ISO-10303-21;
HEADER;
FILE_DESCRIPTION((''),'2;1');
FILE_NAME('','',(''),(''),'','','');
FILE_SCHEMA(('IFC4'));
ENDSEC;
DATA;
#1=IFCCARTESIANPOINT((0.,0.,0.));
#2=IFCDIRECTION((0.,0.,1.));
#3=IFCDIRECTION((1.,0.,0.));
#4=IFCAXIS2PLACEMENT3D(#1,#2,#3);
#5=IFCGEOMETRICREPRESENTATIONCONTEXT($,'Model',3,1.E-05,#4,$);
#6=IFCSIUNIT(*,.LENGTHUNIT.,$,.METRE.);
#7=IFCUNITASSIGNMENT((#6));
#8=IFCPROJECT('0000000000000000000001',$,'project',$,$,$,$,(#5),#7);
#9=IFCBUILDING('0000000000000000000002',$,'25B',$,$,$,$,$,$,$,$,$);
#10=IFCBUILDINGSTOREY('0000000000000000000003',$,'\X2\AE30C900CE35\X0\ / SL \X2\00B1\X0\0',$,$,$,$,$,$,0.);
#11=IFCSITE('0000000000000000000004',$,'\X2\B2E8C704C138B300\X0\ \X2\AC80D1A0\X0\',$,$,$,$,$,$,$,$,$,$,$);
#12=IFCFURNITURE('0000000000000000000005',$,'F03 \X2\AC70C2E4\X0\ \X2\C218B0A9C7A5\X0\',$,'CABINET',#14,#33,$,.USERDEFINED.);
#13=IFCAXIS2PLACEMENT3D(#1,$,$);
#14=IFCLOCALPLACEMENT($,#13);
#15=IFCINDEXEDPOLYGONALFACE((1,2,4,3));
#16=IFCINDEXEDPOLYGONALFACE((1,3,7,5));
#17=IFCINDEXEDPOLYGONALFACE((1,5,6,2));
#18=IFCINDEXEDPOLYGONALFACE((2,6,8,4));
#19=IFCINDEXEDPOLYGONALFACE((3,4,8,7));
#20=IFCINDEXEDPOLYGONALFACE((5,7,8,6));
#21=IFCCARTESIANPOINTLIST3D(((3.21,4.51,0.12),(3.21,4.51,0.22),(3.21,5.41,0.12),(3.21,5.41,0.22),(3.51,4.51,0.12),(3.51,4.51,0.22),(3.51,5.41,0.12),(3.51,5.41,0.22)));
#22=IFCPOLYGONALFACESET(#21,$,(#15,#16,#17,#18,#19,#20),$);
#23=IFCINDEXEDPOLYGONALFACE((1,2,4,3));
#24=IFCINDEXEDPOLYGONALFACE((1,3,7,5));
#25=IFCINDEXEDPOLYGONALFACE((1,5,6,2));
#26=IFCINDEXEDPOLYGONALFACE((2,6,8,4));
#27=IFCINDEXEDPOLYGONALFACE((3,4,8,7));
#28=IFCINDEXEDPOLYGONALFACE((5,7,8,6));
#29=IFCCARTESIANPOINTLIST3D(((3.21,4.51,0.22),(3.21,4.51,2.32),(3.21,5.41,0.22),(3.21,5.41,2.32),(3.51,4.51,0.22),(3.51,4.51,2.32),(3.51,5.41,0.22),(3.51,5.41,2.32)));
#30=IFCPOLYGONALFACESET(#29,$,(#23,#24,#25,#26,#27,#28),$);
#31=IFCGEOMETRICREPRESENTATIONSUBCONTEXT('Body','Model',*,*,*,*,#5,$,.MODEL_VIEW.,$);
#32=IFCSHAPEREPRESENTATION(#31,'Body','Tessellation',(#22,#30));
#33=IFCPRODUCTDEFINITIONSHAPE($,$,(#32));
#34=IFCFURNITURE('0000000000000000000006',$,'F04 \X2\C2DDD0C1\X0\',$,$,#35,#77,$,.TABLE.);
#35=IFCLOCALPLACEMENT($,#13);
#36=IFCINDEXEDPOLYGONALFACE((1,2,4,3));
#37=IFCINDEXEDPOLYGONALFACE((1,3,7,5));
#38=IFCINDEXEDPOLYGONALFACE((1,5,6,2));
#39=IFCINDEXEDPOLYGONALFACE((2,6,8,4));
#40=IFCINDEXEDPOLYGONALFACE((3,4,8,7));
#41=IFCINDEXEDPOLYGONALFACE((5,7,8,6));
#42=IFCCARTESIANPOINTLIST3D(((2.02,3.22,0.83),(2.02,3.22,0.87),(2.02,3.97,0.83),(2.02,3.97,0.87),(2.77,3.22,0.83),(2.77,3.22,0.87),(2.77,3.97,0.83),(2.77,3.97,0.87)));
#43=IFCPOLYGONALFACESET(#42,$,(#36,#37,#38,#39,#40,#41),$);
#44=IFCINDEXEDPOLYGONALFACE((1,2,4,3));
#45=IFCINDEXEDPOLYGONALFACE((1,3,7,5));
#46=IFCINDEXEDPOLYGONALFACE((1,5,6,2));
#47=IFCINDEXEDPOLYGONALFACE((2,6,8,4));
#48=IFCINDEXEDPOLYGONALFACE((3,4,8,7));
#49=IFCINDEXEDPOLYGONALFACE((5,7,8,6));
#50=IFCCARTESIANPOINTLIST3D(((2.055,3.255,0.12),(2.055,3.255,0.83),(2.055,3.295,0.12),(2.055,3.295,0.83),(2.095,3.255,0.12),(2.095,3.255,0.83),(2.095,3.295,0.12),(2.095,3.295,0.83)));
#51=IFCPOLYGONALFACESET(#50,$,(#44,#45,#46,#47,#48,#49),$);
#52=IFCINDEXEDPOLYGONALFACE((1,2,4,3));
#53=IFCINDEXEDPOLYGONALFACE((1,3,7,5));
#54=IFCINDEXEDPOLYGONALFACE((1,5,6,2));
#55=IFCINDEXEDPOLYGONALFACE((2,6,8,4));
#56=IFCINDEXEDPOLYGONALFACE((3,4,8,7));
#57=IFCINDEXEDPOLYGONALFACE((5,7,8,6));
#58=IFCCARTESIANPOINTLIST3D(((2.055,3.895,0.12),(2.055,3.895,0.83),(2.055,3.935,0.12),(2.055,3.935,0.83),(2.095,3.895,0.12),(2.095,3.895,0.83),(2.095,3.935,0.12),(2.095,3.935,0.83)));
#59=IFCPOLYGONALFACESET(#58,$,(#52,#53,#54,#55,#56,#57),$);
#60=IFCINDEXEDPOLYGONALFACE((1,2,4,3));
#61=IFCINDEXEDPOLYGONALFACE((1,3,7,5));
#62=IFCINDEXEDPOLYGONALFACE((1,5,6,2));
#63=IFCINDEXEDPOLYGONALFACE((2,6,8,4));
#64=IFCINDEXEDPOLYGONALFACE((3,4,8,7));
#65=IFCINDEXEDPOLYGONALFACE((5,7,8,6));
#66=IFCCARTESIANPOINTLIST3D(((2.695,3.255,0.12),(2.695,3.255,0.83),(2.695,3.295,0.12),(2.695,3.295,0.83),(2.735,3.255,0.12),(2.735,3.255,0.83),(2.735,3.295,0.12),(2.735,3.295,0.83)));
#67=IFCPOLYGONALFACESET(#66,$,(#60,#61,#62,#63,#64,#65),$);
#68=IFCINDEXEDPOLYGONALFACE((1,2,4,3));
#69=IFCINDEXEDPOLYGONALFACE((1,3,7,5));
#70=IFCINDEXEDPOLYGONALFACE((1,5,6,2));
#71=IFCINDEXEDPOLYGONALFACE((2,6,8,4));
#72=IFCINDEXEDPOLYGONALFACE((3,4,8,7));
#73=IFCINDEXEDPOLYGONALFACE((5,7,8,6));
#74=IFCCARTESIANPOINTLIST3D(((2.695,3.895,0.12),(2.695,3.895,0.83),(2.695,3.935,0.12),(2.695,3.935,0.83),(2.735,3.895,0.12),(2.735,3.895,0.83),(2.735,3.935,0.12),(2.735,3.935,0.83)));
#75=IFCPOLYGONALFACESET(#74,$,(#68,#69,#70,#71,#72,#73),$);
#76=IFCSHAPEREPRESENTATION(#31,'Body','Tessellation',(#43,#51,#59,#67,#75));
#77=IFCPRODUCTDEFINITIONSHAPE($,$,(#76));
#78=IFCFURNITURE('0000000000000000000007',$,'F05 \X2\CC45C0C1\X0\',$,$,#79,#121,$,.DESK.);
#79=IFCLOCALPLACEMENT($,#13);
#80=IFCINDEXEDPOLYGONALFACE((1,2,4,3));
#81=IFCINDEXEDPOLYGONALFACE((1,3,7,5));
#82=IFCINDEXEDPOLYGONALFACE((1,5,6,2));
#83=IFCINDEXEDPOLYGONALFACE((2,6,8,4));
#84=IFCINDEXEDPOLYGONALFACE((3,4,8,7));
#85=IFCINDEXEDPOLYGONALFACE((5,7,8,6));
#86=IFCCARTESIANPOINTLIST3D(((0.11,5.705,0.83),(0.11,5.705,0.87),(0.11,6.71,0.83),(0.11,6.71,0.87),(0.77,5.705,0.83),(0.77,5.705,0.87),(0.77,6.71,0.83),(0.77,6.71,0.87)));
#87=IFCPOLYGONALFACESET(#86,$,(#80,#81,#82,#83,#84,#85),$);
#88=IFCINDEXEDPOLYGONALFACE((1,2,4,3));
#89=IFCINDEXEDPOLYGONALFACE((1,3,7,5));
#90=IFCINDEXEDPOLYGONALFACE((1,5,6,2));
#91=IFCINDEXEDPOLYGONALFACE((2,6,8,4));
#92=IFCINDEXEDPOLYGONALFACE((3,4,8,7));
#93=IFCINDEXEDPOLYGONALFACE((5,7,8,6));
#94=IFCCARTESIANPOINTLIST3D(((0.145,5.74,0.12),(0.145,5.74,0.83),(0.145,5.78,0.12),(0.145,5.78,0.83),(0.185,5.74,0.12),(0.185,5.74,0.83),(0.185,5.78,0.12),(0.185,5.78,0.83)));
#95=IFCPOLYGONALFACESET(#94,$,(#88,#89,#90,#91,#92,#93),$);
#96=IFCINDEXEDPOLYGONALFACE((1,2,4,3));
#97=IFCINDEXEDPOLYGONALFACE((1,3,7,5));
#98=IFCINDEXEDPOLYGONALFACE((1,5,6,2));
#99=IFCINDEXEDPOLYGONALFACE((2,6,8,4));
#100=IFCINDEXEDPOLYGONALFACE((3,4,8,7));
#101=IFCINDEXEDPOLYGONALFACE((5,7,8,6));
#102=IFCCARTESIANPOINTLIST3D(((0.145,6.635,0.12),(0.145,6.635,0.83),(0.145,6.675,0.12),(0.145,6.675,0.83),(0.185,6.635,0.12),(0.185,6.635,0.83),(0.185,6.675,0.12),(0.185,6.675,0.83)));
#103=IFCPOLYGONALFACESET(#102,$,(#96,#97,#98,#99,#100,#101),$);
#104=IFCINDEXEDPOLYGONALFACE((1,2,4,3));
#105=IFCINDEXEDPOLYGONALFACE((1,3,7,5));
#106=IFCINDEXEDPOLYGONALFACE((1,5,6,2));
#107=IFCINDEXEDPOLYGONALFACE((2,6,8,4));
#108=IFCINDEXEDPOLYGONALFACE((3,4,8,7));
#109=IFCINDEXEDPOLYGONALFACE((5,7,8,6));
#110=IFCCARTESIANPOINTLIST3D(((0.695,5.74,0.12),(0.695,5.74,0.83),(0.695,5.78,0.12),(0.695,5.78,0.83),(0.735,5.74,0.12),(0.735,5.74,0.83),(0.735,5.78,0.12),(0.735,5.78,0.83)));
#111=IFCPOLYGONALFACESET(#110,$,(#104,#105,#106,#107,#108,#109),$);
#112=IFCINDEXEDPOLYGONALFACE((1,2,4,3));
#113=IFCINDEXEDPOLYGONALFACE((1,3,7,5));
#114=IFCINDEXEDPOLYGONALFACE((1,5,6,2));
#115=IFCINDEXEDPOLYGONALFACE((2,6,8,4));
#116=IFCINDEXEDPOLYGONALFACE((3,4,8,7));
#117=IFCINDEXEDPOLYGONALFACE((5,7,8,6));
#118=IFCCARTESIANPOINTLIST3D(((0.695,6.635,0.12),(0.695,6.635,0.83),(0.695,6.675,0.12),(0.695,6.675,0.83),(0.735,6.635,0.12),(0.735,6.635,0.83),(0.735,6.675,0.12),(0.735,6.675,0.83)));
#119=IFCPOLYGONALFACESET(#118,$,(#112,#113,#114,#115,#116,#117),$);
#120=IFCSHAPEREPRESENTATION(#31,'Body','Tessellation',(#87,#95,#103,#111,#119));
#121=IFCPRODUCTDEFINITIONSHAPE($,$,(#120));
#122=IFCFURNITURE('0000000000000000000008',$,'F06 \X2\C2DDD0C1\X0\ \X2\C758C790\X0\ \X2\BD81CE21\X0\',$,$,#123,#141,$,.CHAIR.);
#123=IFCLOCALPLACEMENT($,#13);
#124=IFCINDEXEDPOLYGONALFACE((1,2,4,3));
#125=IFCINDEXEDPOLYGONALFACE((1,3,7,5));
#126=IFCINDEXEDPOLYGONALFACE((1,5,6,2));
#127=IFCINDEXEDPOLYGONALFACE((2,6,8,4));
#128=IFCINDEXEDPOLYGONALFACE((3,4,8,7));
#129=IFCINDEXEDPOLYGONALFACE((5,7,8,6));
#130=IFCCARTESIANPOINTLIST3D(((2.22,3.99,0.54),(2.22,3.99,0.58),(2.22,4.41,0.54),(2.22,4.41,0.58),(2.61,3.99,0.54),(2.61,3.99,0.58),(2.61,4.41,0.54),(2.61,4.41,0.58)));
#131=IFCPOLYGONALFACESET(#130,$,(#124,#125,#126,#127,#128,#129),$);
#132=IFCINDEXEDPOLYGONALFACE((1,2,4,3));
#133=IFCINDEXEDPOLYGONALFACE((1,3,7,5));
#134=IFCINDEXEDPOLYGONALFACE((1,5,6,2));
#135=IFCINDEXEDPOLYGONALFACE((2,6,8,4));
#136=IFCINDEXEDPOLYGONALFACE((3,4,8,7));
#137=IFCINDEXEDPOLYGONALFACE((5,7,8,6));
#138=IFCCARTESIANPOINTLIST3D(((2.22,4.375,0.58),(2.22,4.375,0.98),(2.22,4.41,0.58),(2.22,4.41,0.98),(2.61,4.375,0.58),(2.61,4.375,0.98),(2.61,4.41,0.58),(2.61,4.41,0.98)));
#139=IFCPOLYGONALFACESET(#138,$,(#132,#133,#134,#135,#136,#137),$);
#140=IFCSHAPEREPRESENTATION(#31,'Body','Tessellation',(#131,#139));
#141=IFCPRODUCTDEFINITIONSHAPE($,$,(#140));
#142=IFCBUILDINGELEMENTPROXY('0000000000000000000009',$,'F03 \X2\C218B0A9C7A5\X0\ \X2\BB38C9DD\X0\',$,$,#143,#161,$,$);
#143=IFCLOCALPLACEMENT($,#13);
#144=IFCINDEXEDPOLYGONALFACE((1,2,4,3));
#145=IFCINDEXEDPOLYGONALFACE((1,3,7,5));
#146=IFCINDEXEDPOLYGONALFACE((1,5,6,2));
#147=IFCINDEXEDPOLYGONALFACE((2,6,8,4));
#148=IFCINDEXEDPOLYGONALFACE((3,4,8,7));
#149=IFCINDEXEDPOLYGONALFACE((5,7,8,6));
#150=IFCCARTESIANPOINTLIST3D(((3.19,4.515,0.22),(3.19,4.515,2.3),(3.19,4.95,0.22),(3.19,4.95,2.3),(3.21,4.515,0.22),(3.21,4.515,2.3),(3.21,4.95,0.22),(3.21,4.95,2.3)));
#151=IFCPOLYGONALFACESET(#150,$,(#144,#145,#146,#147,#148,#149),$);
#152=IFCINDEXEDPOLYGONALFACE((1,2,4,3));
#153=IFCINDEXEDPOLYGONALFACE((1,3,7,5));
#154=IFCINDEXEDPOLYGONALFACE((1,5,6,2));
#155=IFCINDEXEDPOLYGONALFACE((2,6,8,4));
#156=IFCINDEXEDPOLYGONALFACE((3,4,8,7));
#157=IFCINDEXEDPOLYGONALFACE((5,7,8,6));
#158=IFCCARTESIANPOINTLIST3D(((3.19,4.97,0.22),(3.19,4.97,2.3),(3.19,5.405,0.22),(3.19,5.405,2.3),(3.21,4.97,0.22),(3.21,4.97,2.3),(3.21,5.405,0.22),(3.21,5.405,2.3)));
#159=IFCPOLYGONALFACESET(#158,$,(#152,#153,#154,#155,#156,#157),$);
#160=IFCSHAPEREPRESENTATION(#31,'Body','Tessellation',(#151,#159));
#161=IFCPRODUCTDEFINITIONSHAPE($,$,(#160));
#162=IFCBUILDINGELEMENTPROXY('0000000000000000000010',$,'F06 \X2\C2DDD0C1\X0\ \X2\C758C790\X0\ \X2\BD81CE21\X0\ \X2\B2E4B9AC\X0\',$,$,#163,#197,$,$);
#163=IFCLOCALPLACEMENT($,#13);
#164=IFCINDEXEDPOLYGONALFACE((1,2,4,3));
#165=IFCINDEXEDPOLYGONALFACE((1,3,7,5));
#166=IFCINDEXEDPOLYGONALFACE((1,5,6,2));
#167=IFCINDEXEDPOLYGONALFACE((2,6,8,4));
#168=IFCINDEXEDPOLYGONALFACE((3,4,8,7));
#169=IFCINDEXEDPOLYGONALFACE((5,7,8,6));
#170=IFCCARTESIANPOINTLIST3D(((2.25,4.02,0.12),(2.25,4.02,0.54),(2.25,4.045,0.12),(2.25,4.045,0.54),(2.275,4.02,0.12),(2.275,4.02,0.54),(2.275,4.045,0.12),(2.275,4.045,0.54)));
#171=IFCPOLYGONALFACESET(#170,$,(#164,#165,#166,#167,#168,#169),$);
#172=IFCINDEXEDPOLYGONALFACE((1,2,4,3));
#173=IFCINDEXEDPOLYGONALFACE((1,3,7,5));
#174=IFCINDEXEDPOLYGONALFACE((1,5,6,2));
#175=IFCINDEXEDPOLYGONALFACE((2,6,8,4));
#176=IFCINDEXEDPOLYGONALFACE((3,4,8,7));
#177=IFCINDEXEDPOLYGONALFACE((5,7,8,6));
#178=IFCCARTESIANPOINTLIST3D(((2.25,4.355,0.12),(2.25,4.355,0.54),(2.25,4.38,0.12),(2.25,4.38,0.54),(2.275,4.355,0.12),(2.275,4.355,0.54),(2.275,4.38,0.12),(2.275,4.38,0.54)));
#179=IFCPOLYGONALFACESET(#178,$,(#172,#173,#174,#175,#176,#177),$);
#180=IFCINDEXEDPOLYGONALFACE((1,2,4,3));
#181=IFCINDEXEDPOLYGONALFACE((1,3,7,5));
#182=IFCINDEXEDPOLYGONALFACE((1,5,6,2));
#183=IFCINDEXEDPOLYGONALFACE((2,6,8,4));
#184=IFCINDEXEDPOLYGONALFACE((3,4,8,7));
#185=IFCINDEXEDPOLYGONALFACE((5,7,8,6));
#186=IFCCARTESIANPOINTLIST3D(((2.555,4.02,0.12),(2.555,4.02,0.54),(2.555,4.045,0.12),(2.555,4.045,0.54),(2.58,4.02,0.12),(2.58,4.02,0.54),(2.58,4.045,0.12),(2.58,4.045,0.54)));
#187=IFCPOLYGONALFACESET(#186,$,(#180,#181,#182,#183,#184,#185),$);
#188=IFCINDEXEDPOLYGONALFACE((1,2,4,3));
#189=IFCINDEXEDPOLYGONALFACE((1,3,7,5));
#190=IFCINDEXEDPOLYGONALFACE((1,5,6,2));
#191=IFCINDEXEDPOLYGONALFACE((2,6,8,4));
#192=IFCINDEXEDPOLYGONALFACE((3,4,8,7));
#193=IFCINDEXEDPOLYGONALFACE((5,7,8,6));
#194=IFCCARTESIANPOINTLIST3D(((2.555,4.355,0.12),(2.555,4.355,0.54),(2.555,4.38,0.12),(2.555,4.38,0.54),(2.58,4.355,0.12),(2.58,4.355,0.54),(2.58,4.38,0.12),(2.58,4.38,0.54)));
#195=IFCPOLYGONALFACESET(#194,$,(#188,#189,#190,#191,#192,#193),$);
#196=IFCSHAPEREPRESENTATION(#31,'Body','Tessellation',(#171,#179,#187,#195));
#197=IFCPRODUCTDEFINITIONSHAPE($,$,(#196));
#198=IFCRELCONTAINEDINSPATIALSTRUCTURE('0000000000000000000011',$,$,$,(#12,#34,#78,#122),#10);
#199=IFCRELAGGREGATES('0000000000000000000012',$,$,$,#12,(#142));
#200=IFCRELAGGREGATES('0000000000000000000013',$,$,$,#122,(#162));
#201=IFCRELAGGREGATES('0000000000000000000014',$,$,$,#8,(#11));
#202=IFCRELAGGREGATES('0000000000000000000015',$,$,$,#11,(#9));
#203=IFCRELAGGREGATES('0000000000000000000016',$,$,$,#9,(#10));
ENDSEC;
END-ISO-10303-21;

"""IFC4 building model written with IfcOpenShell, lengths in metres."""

from ifc_helpers import new_model, si_unit, frame, origin_with_axes, place, context, subcontext, project, spatial, polyline, outline, extrude, element, aggregate, save


model = new_model("IFC4")

# Units and contexts
model_context = context("Model", 3, precision=1e-05, world=origin_with_axes())
body_context = subcontext(model_context, "Body", "Model", "MODEL_VIEW")
ifc_project = project(units=[si_unit("LENGTHUNIT", "METRE")], contexts=[model_context])

# Site, building, storey
site = spatial("IfcSite", under=ifc_project, Name="단위세대 검토")
building = spatial("IfcBuilding", under=site, Name="25B")
storey = spatial("IfcBuildingStorey", under=building, Name="기준층 / SL ±0", Elevation=0.0)

# Furniture
furniture_1_placement = place(None, origin_with_axes())
furniture_1 = element("IfcFurniture", 1, at=furniture_1_placement, inside=storey, Name="F03 거실 수납장", ObjectType="CABINET", PredefinedType="USERDEFINED", context=body_context, shape_type="SweptSolid", body=[
    extrude(outline(polyline([(3.51, 4.51), (3.51, 5.41), (3.21, 5.41), (3.21, 4.51), (3.51, 4.51)])), frame((0.0, 0.0, 0.12)), (0.0, 0.0, 1.0), 0.1),
    extrude(outline(polyline([(3.51, 4.51), (3.51, 5.41), (3.21, 5.41), (3.21, 4.51), (3.51, 4.51)])), frame((0.0, 0.0, 0.22)), (0.0, 0.0, 1.0), 2.1),
])
furniture_2_placement = place(None, origin_with_axes())
element("IfcFurniture", 2, at=furniture_2_placement, inside=storey, Name="F04 식탁", PredefinedType="TABLE", context=body_context, shape_type="SweptSolid", body=[
    extrude(outline(polyline([(2.77, 3.97), (2.77, 3.22), (2.02, 3.22), (2.02, 3.97), (2.77, 3.97)])), frame((0.0, 0.0, 0.83)), (0.0, 0.0, 1.0), 0.04),
    extrude(outline(polyline([(2.095, 3.255), (2.095, 3.295), (2.055, 3.295), (2.055, 3.255), (2.095, 3.255)])), frame((0.0, 0.0, 0.12)), (0.0, 0.0, 1.0), 0.71),
    extrude(outline(polyline([(2.095, 3.895), (2.095, 3.935), (2.055, 3.935), (2.055, 3.895), (2.095, 3.895)])), frame((0.0, 0.0, 0.12)), (0.0, 0.0, 1.0), 0.71),
    extrude(outline(polyline([(2.735, 3.255), (2.735, 3.295), (2.695, 3.295), (2.695, 3.255), (2.735, 3.255)])), frame((0.0, 0.0, 0.12)), (0.0, 0.0, 1.0), 0.71),
    extrude(outline(polyline([(2.735, 3.895), (2.735, 3.935), (2.695, 3.935), (2.695, 3.895), (2.735, 3.895)])), frame((0.0, 0.0, 0.12)), (0.0, 0.0, 1.0), 0.71),
])
furniture_3_placement = place(None, origin_with_axes())
element("IfcFurniture", 3, at=furniture_3_placement, inside=storey, Name="F05 책상", PredefinedType="DESK", context=body_context, shape_type="SweptSolid", body=[
    extrude(outline(polyline([(0.77, 5.705), (0.77, 6.71), (0.11, 6.71), (0.11, 5.705), (0.77, 5.705)])), frame((0.0, 0.0, 0.83)), (0.0, 0.0, 1.0), 0.04),
    extrude(outline(polyline([(0.185, 5.74), (0.185, 5.78), (0.145, 5.78), (0.145, 5.74), (0.185, 5.74)])), frame((0.0, 0.0, 0.12)), (0.0, 0.0, 1.0), 0.71),
    extrude(outline(polyline([(0.185, 6.635), (0.185, 6.675), (0.145, 6.675), (0.145, 6.635), (0.185, 6.635)])), frame((0.0, 0.0, 0.12)), (0.0, 0.0, 1.0), 0.71),
    extrude(outline(polyline([(0.735, 5.74), (0.735, 5.78), (0.695, 5.78), (0.695, 5.74), (0.735, 5.74)])), frame((0.0, 0.0, 0.12)), (0.0, 0.0, 1.0), 0.71),
    extrude(outline(polyline([(0.735, 6.635), (0.735, 6.675), (0.695, 6.675), (0.695, 6.635), (0.735, 6.635)])), frame((0.0, 0.0, 0.12)), (0.0, 0.0, 1.0), 0.71),
])
furniture_4_placement = place(None, origin_with_axes())
furniture_4 = element("IfcFurniture", 4, at=furniture_4_placement, inside=storey, Name="F06 식탁 의자 북측", PredefinedType="CHAIR", context=body_context, shape_type="SweptSolid", body=[
    extrude(outline(polyline([(2.61, 3.99), (2.61, 4.41), (2.22, 4.41), (2.22, 3.99), (2.61, 3.99)])), frame((0.0, 0.0, 0.54)), (0.0, 0.0, 1.0), 0.04),
    extrude(outline(polyline([(2.61, 4.375), (2.61, 4.41), (2.22, 4.41), (2.22, 4.375), (2.61, 4.375)])), frame((0.0, 0.0, 0.58)), (0.0, 0.0, 1.0), 0.4),
])

# Building element proxies
proxy_1_placement = place(furniture_1_placement, origin_with_axes())
proxy_1 = element("IfcBuildingElementProxy", 5, at=proxy_1_placement, Name="F03 수납장 문짝", context=body_context, shape_type="SweptSolid", body=[
    extrude(outline(polyline([(3.21, 4.515), (3.21, 4.95), (3.19, 4.95), (3.19, 4.515), (3.21, 4.515)])), frame((0.0, 0.0, 0.22)), (0.0, 0.0, 1.0), 2.08),
    extrude(outline(polyline([(3.21, 4.97), (3.21, 5.405), (3.19, 5.405), (3.19, 4.97), (3.21, 4.97)])), frame((0.0, 0.0, 0.22)), (0.0, 0.0, 1.0), 2.08),
])
aggregate(furniture_1, [proxy_1])
proxy_2_placement = place(furniture_4_placement, origin_with_axes())
proxy_2 = element("IfcBuildingElementProxy", 6, at=proxy_2_placement, Name="F06 식탁 의자 북측 다리", context=body_context, shape_type="SweptSolid", body=[
    extrude(outline(polyline([(2.275, 4.02), (2.275, 4.045), (2.25, 4.045), (2.25, 4.02), (2.275, 4.02)])), frame((0.0, 0.0, 0.12)), (0.0, 0.0, 1.0), 0.42),
    extrude(outline(polyline([(2.275, 4.355), (2.275, 4.38), (2.25, 4.38), (2.25, 4.355), (2.275, 4.355)])), frame((0.0, 0.0, 0.12)), (0.0, 0.0, 1.0), 0.42),
    extrude(outline(polyline([(2.58, 4.02), (2.58, 4.045), (2.555, 4.045), (2.555, 4.02), (2.58, 4.02)])), frame((0.0, 0.0, 0.12)), (0.0, 0.0, 1.0), 0.42),
    extrude(outline(polyline([(2.58, 4.355), (2.58, 4.38), (2.555, 4.38), (2.555, 4.355), (2.58, 4.355)])), frame((0.0, 0.0, 0.12)), (0.0, 0.0, 1.0), 0.42),
])
aggregate(furniture_4, [proxy_2])

save(model, "model.ifc")
